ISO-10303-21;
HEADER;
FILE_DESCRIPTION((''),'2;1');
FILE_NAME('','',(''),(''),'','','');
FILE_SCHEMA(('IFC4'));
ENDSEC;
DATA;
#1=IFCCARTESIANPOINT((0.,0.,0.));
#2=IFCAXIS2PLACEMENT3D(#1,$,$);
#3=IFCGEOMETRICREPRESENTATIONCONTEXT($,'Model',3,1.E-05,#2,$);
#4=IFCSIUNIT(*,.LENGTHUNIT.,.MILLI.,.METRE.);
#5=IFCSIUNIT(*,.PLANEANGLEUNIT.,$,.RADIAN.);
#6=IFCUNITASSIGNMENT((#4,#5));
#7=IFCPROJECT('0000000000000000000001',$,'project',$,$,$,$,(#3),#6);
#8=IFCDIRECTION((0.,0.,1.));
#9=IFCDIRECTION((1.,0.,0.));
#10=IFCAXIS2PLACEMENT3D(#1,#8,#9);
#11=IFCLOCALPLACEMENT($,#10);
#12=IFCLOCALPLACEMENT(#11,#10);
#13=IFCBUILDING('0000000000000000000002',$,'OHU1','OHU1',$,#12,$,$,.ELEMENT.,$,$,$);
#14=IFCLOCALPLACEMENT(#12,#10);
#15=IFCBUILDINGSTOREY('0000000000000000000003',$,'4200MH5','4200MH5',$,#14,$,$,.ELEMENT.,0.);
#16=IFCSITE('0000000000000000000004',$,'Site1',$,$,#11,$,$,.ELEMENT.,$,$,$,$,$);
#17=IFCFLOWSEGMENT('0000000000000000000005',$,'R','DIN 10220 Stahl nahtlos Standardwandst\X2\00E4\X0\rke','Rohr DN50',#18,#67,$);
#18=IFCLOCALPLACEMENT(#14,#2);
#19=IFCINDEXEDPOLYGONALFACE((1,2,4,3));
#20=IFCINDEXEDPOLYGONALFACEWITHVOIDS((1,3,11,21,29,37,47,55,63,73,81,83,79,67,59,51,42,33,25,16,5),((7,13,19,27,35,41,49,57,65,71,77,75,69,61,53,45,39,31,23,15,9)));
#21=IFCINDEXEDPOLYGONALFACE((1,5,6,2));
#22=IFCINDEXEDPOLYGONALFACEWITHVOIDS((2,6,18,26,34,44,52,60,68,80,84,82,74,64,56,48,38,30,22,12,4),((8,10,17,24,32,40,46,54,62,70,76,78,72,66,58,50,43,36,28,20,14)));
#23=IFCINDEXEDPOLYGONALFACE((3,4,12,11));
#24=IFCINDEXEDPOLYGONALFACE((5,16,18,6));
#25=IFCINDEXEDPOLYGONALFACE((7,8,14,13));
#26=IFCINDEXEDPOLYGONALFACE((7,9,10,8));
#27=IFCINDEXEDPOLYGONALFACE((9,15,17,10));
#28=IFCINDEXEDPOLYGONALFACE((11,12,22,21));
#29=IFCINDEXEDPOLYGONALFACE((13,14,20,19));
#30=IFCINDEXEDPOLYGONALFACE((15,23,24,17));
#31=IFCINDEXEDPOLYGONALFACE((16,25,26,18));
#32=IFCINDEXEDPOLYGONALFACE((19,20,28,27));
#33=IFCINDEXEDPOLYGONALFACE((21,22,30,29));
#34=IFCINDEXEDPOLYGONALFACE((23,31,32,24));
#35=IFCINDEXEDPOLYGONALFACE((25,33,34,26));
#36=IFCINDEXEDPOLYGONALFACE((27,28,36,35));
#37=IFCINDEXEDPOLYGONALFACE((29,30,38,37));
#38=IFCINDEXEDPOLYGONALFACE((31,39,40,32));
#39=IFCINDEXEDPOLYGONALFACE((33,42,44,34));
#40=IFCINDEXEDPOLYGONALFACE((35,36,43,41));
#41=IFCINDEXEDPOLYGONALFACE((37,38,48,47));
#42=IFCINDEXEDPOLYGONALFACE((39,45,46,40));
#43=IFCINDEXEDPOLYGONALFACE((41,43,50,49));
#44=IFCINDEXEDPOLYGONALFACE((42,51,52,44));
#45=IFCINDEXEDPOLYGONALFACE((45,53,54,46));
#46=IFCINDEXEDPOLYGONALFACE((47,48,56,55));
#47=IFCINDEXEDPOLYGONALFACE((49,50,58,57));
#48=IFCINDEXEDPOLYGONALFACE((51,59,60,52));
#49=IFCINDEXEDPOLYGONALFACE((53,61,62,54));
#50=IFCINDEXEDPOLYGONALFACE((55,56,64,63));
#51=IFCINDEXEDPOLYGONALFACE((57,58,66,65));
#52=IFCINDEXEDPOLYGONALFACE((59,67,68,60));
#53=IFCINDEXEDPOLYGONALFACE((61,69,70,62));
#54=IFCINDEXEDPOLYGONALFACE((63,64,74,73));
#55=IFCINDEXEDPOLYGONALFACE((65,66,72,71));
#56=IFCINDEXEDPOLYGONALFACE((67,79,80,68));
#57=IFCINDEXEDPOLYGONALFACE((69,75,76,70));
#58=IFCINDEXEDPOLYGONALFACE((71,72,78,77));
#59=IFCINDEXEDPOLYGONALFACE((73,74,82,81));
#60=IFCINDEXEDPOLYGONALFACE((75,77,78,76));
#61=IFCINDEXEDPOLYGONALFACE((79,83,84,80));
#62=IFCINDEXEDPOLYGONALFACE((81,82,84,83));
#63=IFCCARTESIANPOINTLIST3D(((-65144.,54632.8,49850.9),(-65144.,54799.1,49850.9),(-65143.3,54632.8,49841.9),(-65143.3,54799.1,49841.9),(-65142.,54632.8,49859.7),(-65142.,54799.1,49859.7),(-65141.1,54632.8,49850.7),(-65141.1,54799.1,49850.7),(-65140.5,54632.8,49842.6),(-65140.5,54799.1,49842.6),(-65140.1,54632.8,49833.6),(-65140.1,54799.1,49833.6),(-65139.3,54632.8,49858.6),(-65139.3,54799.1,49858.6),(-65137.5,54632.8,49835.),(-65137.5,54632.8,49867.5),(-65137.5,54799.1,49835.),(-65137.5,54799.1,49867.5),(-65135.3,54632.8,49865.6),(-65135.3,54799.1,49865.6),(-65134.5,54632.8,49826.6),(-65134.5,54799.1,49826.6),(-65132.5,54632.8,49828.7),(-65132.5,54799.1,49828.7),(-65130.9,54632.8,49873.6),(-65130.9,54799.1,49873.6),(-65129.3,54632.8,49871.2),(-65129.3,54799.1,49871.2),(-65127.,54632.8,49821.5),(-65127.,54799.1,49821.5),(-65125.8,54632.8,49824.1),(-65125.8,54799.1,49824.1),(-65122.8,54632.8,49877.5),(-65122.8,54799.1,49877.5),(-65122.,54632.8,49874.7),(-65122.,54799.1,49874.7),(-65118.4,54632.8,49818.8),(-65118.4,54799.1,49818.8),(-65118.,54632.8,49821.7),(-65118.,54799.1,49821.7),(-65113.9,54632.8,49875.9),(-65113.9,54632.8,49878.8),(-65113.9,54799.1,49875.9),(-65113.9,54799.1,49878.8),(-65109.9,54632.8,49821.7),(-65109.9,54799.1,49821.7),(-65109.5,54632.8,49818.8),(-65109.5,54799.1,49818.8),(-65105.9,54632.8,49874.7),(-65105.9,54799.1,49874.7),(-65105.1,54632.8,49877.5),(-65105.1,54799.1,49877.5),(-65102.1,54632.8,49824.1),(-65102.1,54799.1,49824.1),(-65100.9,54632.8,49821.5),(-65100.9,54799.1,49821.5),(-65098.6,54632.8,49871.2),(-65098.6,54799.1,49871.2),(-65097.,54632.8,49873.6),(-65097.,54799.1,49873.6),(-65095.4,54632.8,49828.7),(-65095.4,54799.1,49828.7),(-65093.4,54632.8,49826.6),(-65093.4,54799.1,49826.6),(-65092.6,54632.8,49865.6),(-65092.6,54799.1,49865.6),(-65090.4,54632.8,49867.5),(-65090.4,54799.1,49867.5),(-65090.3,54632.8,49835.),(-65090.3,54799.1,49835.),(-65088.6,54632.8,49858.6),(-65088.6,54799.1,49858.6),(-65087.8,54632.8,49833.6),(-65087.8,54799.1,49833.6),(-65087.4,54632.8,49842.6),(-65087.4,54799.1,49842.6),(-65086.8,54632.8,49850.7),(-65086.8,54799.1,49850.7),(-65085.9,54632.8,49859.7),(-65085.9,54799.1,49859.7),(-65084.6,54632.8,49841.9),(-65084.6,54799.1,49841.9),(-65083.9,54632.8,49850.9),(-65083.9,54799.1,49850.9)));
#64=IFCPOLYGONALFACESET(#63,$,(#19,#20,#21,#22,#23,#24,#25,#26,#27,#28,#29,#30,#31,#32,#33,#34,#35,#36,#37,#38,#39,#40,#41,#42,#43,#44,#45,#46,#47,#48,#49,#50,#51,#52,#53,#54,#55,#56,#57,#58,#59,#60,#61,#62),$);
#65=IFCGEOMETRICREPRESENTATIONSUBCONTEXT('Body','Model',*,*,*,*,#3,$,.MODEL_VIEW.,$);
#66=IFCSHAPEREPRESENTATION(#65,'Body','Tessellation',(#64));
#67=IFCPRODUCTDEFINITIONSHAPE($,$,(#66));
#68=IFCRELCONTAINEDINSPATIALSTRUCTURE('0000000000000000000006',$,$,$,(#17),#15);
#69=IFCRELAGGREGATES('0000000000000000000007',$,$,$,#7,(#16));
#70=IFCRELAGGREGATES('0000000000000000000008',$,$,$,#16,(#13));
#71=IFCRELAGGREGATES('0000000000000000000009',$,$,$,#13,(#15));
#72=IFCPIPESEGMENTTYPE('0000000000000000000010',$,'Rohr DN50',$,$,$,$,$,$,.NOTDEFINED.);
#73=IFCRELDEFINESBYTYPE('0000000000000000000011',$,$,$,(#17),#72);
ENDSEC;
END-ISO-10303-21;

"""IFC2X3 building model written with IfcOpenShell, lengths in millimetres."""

from ifc_helpers import new_model, si_unit, frame, origin, origin_with_axes, origin_2d_with_axis, place, context, subcontext, project, spatial, hollow_circle, extrude, type_object, element, save


model = new_model("IFC2X3")

# Units and contexts
model_context = context("Model", 3, precision=1e-05, world=origin())
body_context = subcontext(model_context, "Body", "Model", "MODEL_VIEW")
ifc_project = project(units=[si_unit("LENGTHUNIT", "METRE", prefix="MILLI"), si_unit("PLANEANGLEUNIT", "RADIAN")], contexts=[model_context])

# Site, building, storey
site_placement = place(None, origin_with_axes())
site = spatial("IfcSite", under=ifc_project, at=site_placement, Name="Site1", CompositionType="ELEMENT")
building_placement = place(site_placement, origin_with_axes())
building = spatial("IfcBuilding", under=site, at=building_placement, Name="OHU1", Description="OHU1", CompositionType="ELEMENT")
storey_placement = place(building_placement, origin_with_axes())
storey = spatial("IfcBuildingStorey", under=building, at=storey_placement, Name="4200MH5", Description="4200MH5", CompositionType="ELEMENT", Elevation=0.0)

# Flow segment
pipe_segment_type_1 = type_object("IfcPipeSegmentType", Name="Rohr DN50", PredefinedType="NOTDEFINED")
flow_segment_1_placement = place(storey_placement, frame((-65113.9, 54715.9, 49848.7), z_axis=(0.0, 0.0, 1.0), x_axis=(1.0, 0.0, 0.0)))
element("IfcFlowSegment", 1, at=flow_segment_1_placement, inside=storey, type_object=pipe_segment_type_1, Name="R", Description="DIN 10220 Stahl nahtlos Standardwandstärke", ObjectType="Rohr DN50", context=body_context, shape_type="SweptSolid", body=[
    extrude(hollow_circle(Radius=30.1, WallThickness=2.9, at=origin_2d_with_axis()), frame((0.0, 83.2, 0.0), z_axis=(0.0, -1.0, 0.0), x_axis=(0.0, 0.0, 1.0)), (0.0, 0.0, 1.0), 166.3),
])

save(model, "model.ifc")
